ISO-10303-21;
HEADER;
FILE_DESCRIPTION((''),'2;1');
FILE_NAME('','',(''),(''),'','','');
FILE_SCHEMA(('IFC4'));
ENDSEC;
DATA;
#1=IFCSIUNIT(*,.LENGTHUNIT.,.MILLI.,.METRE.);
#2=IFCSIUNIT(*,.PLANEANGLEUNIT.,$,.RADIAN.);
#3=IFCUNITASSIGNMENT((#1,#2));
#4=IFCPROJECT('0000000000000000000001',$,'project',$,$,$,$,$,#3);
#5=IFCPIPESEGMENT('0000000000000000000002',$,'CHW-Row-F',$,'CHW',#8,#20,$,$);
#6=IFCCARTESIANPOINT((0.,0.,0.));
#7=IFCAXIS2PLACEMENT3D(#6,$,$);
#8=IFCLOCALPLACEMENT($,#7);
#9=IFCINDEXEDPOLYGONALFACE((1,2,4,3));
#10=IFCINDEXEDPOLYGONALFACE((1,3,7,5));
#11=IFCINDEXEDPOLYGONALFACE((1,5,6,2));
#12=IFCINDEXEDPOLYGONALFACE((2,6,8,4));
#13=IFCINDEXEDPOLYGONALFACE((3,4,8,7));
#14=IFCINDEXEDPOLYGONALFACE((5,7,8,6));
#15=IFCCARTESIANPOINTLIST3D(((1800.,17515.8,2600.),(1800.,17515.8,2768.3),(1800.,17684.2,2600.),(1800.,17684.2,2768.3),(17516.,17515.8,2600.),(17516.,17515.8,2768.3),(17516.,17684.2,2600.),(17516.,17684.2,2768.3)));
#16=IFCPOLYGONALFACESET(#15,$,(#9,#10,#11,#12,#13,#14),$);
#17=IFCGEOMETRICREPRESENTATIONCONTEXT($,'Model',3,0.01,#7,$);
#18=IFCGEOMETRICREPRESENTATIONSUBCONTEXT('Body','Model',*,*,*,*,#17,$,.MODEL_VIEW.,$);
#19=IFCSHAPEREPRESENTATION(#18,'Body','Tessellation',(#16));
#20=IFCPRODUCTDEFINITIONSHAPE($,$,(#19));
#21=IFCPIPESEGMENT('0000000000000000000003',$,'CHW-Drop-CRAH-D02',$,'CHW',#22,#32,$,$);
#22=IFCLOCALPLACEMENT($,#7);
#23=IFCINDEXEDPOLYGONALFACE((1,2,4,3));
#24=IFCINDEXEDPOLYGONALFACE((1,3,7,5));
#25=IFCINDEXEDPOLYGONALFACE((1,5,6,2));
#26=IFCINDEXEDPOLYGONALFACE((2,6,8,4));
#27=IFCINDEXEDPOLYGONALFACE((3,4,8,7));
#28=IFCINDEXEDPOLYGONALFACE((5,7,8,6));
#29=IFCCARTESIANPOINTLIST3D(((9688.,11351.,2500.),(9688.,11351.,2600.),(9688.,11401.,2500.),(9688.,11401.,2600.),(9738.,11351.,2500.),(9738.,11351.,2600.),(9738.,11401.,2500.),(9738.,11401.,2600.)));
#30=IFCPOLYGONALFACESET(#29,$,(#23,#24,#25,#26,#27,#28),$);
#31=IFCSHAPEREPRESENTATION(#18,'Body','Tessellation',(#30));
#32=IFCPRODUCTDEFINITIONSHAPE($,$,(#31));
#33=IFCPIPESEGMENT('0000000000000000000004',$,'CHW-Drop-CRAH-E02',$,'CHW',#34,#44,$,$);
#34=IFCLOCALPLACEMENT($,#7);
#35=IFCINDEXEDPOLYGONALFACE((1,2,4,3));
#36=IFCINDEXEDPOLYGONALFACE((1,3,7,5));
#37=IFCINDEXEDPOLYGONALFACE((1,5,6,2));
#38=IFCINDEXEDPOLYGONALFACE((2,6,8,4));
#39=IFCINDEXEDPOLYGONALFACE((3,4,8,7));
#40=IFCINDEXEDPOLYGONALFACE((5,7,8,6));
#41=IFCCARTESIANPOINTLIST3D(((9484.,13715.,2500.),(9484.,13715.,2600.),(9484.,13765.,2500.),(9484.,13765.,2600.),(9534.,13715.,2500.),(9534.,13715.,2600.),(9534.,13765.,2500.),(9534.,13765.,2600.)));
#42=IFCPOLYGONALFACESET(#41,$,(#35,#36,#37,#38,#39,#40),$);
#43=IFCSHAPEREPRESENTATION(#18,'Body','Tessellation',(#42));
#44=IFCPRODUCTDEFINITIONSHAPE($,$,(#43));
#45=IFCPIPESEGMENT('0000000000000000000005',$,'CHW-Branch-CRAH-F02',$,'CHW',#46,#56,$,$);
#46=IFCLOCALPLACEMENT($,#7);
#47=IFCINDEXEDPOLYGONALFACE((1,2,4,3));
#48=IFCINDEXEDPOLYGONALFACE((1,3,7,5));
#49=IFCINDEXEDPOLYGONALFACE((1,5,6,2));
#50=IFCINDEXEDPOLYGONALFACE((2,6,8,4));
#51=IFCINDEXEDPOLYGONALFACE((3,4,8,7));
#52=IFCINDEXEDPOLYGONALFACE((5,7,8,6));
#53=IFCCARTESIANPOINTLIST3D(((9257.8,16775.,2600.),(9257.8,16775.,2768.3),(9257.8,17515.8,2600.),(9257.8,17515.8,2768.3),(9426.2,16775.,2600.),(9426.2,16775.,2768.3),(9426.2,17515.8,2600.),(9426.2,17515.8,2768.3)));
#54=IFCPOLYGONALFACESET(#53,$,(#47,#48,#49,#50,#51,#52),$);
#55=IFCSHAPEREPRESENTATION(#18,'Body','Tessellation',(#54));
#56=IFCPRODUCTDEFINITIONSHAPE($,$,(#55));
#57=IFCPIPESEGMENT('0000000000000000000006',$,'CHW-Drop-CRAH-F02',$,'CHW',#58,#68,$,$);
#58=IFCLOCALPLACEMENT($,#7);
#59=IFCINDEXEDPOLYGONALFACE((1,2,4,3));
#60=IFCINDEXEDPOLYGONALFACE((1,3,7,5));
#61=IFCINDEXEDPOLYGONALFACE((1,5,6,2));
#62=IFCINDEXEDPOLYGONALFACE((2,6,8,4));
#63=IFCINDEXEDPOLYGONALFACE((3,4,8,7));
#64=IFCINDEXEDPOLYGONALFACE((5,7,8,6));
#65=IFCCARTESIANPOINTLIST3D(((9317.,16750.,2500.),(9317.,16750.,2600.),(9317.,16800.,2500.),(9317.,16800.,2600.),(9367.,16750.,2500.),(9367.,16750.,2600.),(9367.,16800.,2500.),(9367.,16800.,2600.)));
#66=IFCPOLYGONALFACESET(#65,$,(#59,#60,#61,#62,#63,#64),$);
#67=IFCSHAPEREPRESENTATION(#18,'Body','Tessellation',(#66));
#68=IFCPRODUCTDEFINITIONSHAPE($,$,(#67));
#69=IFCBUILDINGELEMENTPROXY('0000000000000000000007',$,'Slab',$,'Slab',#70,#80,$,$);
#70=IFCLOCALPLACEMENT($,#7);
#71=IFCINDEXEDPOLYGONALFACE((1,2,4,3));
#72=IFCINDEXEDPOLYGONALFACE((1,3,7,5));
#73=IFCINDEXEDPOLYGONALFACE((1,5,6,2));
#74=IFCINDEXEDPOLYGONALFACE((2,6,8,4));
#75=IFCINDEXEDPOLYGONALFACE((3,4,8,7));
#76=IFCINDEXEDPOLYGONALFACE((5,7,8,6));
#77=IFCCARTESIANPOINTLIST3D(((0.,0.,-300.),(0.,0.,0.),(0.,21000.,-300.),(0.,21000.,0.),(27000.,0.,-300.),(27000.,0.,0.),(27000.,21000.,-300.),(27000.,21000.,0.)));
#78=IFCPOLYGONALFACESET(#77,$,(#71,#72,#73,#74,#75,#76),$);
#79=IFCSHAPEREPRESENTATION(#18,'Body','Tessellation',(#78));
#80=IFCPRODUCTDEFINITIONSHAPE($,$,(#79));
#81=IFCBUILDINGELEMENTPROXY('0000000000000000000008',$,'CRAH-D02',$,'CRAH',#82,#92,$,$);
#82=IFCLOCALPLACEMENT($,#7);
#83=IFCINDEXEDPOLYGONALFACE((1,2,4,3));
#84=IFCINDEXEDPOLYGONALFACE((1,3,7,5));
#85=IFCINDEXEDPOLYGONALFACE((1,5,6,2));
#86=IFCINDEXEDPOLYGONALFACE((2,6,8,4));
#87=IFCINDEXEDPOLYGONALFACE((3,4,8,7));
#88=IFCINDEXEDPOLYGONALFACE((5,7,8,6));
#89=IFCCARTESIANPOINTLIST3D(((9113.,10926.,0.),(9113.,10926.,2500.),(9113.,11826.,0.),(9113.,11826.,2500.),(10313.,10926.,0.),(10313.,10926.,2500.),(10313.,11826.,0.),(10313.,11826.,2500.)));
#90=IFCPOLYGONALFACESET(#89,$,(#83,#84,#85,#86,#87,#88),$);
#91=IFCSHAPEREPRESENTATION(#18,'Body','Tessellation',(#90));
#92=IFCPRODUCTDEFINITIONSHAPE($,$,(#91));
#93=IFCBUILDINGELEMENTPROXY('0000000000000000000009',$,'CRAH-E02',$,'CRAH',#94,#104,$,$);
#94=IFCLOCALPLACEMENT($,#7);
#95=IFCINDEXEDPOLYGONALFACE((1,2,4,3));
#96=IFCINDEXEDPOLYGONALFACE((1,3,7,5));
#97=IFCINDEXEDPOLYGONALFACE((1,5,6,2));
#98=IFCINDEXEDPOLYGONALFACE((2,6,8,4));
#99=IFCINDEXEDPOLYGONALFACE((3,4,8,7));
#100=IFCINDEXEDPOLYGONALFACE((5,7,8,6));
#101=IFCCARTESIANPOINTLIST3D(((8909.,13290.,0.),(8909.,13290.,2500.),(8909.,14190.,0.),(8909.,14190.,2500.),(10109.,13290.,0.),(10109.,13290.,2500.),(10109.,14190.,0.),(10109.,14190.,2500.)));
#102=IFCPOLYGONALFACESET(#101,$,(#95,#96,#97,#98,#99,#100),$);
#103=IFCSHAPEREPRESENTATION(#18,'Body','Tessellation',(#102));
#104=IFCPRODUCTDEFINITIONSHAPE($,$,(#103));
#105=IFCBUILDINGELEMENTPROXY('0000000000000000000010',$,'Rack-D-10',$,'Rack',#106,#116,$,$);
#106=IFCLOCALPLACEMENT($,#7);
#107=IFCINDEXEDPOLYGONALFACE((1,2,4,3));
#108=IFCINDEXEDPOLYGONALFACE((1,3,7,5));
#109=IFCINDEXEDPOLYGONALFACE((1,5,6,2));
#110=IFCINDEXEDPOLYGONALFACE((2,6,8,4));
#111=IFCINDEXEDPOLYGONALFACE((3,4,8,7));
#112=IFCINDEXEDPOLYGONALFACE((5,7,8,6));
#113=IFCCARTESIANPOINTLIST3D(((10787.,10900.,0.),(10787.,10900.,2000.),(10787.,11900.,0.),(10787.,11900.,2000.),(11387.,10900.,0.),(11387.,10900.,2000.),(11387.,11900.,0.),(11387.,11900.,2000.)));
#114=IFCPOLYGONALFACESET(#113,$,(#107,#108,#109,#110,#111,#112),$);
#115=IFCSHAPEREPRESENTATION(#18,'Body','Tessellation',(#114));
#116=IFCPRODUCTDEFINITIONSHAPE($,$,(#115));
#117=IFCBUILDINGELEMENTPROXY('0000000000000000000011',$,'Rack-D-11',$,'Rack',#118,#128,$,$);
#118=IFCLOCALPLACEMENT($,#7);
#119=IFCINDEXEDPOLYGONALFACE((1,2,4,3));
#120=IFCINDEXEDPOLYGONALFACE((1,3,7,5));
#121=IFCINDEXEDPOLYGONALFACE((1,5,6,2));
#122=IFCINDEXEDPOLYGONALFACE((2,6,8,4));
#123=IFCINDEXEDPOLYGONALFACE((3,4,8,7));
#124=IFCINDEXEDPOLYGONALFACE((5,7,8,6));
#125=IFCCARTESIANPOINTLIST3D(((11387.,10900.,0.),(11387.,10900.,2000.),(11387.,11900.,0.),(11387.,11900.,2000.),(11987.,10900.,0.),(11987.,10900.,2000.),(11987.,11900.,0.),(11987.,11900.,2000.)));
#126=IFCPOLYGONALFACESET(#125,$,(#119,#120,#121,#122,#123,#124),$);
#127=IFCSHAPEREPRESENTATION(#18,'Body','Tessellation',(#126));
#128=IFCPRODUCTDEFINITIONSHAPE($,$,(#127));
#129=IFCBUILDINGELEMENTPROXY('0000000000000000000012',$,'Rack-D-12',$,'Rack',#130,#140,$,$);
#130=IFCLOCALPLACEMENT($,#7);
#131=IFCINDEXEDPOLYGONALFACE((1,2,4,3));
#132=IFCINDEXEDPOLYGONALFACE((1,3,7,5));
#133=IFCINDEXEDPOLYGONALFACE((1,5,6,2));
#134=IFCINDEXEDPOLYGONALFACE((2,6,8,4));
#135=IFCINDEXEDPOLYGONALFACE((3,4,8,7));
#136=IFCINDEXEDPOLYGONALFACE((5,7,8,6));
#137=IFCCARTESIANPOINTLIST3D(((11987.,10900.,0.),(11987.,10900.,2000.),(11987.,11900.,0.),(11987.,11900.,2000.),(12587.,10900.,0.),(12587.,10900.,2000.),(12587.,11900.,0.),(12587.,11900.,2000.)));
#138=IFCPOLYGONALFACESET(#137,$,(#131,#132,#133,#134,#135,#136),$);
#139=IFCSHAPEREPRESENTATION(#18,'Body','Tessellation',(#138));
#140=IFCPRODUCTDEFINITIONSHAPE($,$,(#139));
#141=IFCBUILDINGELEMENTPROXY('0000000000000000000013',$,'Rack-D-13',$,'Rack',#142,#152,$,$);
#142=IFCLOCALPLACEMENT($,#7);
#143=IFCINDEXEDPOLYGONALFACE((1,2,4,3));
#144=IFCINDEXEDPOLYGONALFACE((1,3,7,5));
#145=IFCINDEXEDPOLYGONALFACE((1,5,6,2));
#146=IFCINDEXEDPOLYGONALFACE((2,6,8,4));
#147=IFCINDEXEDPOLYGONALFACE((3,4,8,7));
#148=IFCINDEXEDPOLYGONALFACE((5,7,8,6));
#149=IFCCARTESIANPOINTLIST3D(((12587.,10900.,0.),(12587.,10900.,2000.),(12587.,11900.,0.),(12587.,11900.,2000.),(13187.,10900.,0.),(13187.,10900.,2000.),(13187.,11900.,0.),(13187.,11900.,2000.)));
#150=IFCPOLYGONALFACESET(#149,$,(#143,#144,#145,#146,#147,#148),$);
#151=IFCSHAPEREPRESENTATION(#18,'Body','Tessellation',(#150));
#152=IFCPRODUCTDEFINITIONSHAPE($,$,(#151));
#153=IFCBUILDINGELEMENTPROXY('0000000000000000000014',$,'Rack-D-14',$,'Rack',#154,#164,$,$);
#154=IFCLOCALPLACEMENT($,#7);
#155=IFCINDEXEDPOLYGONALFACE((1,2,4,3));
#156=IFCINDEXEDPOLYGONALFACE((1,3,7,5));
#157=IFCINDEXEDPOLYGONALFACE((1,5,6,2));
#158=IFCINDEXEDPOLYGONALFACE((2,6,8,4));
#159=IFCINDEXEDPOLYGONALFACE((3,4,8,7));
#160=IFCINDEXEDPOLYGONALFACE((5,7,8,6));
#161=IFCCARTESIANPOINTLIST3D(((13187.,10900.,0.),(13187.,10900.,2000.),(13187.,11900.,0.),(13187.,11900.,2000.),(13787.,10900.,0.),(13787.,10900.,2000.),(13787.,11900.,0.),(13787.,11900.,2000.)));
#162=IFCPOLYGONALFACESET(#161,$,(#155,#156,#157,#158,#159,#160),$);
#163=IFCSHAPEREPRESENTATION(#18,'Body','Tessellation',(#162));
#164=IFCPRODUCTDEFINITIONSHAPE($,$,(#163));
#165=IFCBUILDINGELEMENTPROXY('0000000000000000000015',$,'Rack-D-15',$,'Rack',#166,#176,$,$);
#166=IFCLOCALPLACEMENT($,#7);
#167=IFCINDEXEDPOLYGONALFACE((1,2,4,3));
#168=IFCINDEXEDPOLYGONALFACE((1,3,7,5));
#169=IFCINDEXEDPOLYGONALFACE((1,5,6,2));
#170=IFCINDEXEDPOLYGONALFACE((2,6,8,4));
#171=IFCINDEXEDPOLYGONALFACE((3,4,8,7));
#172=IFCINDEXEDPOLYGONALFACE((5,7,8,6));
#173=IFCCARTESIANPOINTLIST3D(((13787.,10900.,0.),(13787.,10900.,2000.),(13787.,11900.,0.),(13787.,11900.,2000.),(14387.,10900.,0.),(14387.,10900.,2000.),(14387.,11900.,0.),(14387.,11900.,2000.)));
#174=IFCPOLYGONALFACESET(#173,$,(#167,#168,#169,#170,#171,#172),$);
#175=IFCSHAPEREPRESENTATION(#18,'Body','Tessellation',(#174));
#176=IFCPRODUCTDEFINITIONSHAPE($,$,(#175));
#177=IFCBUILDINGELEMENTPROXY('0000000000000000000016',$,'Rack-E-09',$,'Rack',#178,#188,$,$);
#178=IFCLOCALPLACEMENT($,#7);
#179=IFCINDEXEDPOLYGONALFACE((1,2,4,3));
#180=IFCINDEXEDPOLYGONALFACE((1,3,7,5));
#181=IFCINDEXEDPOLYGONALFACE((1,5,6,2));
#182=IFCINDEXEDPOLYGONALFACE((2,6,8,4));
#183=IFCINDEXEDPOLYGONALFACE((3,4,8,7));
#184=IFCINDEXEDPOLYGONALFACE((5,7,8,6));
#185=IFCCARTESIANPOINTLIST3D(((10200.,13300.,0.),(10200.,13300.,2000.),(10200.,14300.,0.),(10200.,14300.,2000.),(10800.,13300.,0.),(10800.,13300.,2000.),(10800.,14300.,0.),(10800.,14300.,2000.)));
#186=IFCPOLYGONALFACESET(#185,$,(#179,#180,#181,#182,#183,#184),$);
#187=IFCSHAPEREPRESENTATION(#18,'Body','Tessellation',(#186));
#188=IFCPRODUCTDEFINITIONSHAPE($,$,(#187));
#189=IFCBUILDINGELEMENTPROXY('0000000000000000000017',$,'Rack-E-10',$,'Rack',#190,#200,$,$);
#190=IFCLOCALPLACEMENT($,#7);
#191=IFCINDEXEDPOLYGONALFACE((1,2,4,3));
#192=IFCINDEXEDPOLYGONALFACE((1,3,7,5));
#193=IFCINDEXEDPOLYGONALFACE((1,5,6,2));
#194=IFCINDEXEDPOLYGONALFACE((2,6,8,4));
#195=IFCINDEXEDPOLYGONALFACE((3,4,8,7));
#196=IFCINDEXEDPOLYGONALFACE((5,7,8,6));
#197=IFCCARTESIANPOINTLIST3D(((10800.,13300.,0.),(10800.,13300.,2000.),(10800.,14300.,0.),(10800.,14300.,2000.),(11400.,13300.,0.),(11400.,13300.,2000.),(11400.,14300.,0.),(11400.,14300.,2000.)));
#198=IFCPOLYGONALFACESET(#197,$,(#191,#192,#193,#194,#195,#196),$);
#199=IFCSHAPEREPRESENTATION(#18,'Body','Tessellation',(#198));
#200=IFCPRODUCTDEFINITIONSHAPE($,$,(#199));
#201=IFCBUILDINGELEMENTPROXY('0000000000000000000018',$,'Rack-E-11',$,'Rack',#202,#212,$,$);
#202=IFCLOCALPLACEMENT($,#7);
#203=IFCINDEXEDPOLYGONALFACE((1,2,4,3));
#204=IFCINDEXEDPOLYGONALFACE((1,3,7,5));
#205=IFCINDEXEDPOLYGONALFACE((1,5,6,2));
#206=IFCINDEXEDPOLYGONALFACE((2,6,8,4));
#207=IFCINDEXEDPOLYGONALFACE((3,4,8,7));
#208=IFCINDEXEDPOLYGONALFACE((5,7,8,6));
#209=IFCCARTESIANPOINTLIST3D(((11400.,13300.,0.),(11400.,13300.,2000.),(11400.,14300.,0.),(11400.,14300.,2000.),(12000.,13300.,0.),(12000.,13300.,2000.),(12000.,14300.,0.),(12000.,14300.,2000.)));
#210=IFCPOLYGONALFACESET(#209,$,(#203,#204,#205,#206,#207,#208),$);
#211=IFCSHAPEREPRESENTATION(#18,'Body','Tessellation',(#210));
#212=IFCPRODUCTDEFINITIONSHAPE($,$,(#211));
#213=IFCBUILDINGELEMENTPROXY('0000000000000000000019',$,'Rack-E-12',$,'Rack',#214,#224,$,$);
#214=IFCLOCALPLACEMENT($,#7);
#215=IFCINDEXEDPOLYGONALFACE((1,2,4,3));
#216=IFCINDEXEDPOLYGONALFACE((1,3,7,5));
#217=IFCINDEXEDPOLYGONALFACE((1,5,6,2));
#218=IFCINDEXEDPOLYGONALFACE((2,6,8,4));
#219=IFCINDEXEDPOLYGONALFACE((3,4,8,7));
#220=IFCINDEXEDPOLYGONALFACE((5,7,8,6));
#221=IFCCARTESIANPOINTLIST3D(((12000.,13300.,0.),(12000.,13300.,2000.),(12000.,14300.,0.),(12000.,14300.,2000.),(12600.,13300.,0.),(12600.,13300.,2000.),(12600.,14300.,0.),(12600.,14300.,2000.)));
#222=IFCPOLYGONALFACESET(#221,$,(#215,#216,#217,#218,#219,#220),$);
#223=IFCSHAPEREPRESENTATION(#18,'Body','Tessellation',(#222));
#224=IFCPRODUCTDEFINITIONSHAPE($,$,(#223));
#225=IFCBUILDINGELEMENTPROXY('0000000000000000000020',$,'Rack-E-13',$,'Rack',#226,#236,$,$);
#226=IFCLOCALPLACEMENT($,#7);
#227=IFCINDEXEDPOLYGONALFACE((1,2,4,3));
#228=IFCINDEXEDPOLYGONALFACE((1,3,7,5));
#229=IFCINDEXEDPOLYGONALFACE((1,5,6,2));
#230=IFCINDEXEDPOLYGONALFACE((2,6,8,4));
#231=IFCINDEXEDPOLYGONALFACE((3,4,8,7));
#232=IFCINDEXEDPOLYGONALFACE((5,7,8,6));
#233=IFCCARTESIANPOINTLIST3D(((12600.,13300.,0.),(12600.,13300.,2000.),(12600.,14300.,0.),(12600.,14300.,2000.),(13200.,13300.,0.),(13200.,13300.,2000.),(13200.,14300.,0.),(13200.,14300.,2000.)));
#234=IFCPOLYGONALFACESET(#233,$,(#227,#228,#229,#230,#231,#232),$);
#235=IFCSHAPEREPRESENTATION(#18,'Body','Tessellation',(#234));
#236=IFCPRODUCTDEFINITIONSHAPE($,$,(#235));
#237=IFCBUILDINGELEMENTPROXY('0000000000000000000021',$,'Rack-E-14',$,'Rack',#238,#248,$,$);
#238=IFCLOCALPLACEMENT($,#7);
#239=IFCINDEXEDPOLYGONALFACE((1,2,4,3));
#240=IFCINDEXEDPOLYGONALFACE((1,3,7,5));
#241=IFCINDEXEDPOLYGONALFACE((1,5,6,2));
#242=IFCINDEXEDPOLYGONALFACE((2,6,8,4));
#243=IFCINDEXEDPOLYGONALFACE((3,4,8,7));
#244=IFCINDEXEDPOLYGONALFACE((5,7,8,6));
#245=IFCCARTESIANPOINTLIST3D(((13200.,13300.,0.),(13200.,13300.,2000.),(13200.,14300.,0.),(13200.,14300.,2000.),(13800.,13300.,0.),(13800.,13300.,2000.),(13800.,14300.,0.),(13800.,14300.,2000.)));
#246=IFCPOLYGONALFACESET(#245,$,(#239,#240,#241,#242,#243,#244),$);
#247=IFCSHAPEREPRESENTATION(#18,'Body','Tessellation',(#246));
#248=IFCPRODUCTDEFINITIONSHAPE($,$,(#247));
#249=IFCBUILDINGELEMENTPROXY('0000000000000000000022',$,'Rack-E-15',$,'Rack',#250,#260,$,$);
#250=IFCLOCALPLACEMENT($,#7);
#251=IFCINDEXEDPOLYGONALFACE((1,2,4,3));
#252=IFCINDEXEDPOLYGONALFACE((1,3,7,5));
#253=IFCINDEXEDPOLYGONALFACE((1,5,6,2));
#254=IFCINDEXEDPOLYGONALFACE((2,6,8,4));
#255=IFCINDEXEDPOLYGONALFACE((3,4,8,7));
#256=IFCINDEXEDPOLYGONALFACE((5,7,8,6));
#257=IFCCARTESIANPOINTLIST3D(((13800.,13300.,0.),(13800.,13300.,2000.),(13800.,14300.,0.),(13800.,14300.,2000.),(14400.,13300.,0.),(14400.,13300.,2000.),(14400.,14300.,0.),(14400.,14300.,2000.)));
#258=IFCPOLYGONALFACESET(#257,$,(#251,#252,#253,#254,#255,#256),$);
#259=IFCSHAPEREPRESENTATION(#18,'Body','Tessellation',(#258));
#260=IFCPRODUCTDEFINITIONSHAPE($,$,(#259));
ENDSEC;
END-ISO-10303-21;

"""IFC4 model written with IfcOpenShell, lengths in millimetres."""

from ifc_helpers import new_model, si_unit, frame, origin, place, context, subcontext, project, rectangle, extrude, element, save


model = new_model("IFC4")

# Units and contexts
model_context = context("Model", 3, precision=0.01, world=origin())
body_context = subcontext(model_context, "Body", "Model", "MODEL_VIEW")
ifc_project = project(units=[si_unit("LENGTHUNIT", "METRE", prefix="MILLI"), si_unit("PLANEANGLEUNIT", "RADIAN")])

# Pipe segments
placement = place(None, origin())
pipe_segment_1_placement = place(placement, frame((9658.0, 17600.0, 2600.0)))
element("IfcPipeSegment", 1, at=pipe_segment_1_placement, Name="CHW-Row-F", ObjectType="CHW", context=body_context, shape_type="SweptSolid", body=[
    extrude(rectangle(XDim=15716.0, YDim=168.3), origin(), (0.0, 0.0, 1.0), 168.3),
])
for number, where, name in (
    (2, (9713.0, 11376.0, 2500.0), "CHW-Drop-CRAH-D02"),
    (3, (9509.0, 13740.0, 2500.0), "CHW-Drop-CRAH-E02"),
):
    element("IfcPipeSegment", number, at=place(placement, frame(where)), Name=name, ObjectType="CHW", context=body_context, shape_type="SweptSolid", body=[
        extrude(rectangle(XDim=50.0, YDim=50.0), origin(), (0.0, 0.0, 1.0), 100.0),
    ])
pipe_segment_2_placement = place(placement, frame((9342.0, 17145.4, 2600.0)))
element("IfcPipeSegment", 4, at=pipe_segment_2_placement, Name="CHW-Branch-CRAH-F02", ObjectType="CHW", context=body_context, shape_type="SweptSolid", body=[
    extrude(rectangle(XDim=168.3, YDim=740.8), origin(), (0.0, 0.0, 1.0), 168.3),
])
pipe_segment_3_placement = place(placement, frame((9342.0, 16775.0, 2500.0)))
element("IfcPipeSegment", 5, at=pipe_segment_3_placement, Name="CHW-Drop-CRAH-F02", ObjectType="CHW", context=body_context, shape_type="SweptSolid", body=[
    extrude(rectangle(XDim=50.0, YDim=50.0), origin(), (0.0, 0.0, 1.0), 100.0),
])

# Building element proxies
proxy_placement = place(placement, frame((13500.0, 10500.0, -300.0)))
element("IfcBuildingElementProxy", 6, at=proxy_placement, Name="Slab", ObjectType="Slab", context=body_context, shape_type="SweptSolid", body=[
    extrude(rectangle(XDim=27000.0, YDim=21000.0), origin(), (0.0, 0.0, 1.0), 300.0),
])
for number, where, name in (
    (7, (9713.0, 11376.0, 0.0), "CRAH-D02"),
    (8, (9509.0, 13740.0, 0.0), "CRAH-E02"),
):
    element("IfcBuildingElementProxy", number, at=place(placement, frame(where)), Name=name, ObjectType="CRAH", context=body_context, shape_type="SweptSolid", body=[
        extrude(rectangle(XDim=1200.0, YDim=900.0), origin(), (0.0, 0.0, 1.0), 2500.0),
    ])
for number, where, name in (
    (9, (11087.0, 11400.0, 0.0), "Rack-D-10"),
    (10, (11687.0, 11400.0, 0.0), "Rack-D-11"),
    (11, (12287.0, 11400.0, 0.0), "Rack-D-12"),
    (12, (12887.0, 11400.0, 0.0), "Rack-D-13"),
    (13, (13487.0, 11400.0, 0.0), "Rack-D-14"),
    (14, (14087.0, 11400.0, 0.0), "Rack-D-15"),
    (15, (10500.0, 13800.0, 0.0), "Rack-E-09"),
    (16, (11100.0, 13800.0, 0.0), "Rack-E-10"),
    (17, (11700.0, 13800.0, 0.0), "Rack-E-11"),
    (18, (12300.0, 13800.0, 0.0), "Rack-E-12"),
    (19, (12900.0, 13800.0, 0.0), "Rack-E-13"),
    (20, (13500.0, 13800.0, 0.0), "Rack-E-14"),
    (21, (14100.0, 13800.0, 0.0), "Rack-E-15"),
):
    element("IfcBuildingElementProxy", number, at=place(placement, frame(where)), Name=name, ObjectType="Rack", context=body_context, shape_type="SweptSolid", body=[
        extrude(rectangle(XDim=600.0, YDim=1000.0), origin(), (0.0, 0.0, 1.0), 2000.0),
    ])

save(model, "model.ifc")
